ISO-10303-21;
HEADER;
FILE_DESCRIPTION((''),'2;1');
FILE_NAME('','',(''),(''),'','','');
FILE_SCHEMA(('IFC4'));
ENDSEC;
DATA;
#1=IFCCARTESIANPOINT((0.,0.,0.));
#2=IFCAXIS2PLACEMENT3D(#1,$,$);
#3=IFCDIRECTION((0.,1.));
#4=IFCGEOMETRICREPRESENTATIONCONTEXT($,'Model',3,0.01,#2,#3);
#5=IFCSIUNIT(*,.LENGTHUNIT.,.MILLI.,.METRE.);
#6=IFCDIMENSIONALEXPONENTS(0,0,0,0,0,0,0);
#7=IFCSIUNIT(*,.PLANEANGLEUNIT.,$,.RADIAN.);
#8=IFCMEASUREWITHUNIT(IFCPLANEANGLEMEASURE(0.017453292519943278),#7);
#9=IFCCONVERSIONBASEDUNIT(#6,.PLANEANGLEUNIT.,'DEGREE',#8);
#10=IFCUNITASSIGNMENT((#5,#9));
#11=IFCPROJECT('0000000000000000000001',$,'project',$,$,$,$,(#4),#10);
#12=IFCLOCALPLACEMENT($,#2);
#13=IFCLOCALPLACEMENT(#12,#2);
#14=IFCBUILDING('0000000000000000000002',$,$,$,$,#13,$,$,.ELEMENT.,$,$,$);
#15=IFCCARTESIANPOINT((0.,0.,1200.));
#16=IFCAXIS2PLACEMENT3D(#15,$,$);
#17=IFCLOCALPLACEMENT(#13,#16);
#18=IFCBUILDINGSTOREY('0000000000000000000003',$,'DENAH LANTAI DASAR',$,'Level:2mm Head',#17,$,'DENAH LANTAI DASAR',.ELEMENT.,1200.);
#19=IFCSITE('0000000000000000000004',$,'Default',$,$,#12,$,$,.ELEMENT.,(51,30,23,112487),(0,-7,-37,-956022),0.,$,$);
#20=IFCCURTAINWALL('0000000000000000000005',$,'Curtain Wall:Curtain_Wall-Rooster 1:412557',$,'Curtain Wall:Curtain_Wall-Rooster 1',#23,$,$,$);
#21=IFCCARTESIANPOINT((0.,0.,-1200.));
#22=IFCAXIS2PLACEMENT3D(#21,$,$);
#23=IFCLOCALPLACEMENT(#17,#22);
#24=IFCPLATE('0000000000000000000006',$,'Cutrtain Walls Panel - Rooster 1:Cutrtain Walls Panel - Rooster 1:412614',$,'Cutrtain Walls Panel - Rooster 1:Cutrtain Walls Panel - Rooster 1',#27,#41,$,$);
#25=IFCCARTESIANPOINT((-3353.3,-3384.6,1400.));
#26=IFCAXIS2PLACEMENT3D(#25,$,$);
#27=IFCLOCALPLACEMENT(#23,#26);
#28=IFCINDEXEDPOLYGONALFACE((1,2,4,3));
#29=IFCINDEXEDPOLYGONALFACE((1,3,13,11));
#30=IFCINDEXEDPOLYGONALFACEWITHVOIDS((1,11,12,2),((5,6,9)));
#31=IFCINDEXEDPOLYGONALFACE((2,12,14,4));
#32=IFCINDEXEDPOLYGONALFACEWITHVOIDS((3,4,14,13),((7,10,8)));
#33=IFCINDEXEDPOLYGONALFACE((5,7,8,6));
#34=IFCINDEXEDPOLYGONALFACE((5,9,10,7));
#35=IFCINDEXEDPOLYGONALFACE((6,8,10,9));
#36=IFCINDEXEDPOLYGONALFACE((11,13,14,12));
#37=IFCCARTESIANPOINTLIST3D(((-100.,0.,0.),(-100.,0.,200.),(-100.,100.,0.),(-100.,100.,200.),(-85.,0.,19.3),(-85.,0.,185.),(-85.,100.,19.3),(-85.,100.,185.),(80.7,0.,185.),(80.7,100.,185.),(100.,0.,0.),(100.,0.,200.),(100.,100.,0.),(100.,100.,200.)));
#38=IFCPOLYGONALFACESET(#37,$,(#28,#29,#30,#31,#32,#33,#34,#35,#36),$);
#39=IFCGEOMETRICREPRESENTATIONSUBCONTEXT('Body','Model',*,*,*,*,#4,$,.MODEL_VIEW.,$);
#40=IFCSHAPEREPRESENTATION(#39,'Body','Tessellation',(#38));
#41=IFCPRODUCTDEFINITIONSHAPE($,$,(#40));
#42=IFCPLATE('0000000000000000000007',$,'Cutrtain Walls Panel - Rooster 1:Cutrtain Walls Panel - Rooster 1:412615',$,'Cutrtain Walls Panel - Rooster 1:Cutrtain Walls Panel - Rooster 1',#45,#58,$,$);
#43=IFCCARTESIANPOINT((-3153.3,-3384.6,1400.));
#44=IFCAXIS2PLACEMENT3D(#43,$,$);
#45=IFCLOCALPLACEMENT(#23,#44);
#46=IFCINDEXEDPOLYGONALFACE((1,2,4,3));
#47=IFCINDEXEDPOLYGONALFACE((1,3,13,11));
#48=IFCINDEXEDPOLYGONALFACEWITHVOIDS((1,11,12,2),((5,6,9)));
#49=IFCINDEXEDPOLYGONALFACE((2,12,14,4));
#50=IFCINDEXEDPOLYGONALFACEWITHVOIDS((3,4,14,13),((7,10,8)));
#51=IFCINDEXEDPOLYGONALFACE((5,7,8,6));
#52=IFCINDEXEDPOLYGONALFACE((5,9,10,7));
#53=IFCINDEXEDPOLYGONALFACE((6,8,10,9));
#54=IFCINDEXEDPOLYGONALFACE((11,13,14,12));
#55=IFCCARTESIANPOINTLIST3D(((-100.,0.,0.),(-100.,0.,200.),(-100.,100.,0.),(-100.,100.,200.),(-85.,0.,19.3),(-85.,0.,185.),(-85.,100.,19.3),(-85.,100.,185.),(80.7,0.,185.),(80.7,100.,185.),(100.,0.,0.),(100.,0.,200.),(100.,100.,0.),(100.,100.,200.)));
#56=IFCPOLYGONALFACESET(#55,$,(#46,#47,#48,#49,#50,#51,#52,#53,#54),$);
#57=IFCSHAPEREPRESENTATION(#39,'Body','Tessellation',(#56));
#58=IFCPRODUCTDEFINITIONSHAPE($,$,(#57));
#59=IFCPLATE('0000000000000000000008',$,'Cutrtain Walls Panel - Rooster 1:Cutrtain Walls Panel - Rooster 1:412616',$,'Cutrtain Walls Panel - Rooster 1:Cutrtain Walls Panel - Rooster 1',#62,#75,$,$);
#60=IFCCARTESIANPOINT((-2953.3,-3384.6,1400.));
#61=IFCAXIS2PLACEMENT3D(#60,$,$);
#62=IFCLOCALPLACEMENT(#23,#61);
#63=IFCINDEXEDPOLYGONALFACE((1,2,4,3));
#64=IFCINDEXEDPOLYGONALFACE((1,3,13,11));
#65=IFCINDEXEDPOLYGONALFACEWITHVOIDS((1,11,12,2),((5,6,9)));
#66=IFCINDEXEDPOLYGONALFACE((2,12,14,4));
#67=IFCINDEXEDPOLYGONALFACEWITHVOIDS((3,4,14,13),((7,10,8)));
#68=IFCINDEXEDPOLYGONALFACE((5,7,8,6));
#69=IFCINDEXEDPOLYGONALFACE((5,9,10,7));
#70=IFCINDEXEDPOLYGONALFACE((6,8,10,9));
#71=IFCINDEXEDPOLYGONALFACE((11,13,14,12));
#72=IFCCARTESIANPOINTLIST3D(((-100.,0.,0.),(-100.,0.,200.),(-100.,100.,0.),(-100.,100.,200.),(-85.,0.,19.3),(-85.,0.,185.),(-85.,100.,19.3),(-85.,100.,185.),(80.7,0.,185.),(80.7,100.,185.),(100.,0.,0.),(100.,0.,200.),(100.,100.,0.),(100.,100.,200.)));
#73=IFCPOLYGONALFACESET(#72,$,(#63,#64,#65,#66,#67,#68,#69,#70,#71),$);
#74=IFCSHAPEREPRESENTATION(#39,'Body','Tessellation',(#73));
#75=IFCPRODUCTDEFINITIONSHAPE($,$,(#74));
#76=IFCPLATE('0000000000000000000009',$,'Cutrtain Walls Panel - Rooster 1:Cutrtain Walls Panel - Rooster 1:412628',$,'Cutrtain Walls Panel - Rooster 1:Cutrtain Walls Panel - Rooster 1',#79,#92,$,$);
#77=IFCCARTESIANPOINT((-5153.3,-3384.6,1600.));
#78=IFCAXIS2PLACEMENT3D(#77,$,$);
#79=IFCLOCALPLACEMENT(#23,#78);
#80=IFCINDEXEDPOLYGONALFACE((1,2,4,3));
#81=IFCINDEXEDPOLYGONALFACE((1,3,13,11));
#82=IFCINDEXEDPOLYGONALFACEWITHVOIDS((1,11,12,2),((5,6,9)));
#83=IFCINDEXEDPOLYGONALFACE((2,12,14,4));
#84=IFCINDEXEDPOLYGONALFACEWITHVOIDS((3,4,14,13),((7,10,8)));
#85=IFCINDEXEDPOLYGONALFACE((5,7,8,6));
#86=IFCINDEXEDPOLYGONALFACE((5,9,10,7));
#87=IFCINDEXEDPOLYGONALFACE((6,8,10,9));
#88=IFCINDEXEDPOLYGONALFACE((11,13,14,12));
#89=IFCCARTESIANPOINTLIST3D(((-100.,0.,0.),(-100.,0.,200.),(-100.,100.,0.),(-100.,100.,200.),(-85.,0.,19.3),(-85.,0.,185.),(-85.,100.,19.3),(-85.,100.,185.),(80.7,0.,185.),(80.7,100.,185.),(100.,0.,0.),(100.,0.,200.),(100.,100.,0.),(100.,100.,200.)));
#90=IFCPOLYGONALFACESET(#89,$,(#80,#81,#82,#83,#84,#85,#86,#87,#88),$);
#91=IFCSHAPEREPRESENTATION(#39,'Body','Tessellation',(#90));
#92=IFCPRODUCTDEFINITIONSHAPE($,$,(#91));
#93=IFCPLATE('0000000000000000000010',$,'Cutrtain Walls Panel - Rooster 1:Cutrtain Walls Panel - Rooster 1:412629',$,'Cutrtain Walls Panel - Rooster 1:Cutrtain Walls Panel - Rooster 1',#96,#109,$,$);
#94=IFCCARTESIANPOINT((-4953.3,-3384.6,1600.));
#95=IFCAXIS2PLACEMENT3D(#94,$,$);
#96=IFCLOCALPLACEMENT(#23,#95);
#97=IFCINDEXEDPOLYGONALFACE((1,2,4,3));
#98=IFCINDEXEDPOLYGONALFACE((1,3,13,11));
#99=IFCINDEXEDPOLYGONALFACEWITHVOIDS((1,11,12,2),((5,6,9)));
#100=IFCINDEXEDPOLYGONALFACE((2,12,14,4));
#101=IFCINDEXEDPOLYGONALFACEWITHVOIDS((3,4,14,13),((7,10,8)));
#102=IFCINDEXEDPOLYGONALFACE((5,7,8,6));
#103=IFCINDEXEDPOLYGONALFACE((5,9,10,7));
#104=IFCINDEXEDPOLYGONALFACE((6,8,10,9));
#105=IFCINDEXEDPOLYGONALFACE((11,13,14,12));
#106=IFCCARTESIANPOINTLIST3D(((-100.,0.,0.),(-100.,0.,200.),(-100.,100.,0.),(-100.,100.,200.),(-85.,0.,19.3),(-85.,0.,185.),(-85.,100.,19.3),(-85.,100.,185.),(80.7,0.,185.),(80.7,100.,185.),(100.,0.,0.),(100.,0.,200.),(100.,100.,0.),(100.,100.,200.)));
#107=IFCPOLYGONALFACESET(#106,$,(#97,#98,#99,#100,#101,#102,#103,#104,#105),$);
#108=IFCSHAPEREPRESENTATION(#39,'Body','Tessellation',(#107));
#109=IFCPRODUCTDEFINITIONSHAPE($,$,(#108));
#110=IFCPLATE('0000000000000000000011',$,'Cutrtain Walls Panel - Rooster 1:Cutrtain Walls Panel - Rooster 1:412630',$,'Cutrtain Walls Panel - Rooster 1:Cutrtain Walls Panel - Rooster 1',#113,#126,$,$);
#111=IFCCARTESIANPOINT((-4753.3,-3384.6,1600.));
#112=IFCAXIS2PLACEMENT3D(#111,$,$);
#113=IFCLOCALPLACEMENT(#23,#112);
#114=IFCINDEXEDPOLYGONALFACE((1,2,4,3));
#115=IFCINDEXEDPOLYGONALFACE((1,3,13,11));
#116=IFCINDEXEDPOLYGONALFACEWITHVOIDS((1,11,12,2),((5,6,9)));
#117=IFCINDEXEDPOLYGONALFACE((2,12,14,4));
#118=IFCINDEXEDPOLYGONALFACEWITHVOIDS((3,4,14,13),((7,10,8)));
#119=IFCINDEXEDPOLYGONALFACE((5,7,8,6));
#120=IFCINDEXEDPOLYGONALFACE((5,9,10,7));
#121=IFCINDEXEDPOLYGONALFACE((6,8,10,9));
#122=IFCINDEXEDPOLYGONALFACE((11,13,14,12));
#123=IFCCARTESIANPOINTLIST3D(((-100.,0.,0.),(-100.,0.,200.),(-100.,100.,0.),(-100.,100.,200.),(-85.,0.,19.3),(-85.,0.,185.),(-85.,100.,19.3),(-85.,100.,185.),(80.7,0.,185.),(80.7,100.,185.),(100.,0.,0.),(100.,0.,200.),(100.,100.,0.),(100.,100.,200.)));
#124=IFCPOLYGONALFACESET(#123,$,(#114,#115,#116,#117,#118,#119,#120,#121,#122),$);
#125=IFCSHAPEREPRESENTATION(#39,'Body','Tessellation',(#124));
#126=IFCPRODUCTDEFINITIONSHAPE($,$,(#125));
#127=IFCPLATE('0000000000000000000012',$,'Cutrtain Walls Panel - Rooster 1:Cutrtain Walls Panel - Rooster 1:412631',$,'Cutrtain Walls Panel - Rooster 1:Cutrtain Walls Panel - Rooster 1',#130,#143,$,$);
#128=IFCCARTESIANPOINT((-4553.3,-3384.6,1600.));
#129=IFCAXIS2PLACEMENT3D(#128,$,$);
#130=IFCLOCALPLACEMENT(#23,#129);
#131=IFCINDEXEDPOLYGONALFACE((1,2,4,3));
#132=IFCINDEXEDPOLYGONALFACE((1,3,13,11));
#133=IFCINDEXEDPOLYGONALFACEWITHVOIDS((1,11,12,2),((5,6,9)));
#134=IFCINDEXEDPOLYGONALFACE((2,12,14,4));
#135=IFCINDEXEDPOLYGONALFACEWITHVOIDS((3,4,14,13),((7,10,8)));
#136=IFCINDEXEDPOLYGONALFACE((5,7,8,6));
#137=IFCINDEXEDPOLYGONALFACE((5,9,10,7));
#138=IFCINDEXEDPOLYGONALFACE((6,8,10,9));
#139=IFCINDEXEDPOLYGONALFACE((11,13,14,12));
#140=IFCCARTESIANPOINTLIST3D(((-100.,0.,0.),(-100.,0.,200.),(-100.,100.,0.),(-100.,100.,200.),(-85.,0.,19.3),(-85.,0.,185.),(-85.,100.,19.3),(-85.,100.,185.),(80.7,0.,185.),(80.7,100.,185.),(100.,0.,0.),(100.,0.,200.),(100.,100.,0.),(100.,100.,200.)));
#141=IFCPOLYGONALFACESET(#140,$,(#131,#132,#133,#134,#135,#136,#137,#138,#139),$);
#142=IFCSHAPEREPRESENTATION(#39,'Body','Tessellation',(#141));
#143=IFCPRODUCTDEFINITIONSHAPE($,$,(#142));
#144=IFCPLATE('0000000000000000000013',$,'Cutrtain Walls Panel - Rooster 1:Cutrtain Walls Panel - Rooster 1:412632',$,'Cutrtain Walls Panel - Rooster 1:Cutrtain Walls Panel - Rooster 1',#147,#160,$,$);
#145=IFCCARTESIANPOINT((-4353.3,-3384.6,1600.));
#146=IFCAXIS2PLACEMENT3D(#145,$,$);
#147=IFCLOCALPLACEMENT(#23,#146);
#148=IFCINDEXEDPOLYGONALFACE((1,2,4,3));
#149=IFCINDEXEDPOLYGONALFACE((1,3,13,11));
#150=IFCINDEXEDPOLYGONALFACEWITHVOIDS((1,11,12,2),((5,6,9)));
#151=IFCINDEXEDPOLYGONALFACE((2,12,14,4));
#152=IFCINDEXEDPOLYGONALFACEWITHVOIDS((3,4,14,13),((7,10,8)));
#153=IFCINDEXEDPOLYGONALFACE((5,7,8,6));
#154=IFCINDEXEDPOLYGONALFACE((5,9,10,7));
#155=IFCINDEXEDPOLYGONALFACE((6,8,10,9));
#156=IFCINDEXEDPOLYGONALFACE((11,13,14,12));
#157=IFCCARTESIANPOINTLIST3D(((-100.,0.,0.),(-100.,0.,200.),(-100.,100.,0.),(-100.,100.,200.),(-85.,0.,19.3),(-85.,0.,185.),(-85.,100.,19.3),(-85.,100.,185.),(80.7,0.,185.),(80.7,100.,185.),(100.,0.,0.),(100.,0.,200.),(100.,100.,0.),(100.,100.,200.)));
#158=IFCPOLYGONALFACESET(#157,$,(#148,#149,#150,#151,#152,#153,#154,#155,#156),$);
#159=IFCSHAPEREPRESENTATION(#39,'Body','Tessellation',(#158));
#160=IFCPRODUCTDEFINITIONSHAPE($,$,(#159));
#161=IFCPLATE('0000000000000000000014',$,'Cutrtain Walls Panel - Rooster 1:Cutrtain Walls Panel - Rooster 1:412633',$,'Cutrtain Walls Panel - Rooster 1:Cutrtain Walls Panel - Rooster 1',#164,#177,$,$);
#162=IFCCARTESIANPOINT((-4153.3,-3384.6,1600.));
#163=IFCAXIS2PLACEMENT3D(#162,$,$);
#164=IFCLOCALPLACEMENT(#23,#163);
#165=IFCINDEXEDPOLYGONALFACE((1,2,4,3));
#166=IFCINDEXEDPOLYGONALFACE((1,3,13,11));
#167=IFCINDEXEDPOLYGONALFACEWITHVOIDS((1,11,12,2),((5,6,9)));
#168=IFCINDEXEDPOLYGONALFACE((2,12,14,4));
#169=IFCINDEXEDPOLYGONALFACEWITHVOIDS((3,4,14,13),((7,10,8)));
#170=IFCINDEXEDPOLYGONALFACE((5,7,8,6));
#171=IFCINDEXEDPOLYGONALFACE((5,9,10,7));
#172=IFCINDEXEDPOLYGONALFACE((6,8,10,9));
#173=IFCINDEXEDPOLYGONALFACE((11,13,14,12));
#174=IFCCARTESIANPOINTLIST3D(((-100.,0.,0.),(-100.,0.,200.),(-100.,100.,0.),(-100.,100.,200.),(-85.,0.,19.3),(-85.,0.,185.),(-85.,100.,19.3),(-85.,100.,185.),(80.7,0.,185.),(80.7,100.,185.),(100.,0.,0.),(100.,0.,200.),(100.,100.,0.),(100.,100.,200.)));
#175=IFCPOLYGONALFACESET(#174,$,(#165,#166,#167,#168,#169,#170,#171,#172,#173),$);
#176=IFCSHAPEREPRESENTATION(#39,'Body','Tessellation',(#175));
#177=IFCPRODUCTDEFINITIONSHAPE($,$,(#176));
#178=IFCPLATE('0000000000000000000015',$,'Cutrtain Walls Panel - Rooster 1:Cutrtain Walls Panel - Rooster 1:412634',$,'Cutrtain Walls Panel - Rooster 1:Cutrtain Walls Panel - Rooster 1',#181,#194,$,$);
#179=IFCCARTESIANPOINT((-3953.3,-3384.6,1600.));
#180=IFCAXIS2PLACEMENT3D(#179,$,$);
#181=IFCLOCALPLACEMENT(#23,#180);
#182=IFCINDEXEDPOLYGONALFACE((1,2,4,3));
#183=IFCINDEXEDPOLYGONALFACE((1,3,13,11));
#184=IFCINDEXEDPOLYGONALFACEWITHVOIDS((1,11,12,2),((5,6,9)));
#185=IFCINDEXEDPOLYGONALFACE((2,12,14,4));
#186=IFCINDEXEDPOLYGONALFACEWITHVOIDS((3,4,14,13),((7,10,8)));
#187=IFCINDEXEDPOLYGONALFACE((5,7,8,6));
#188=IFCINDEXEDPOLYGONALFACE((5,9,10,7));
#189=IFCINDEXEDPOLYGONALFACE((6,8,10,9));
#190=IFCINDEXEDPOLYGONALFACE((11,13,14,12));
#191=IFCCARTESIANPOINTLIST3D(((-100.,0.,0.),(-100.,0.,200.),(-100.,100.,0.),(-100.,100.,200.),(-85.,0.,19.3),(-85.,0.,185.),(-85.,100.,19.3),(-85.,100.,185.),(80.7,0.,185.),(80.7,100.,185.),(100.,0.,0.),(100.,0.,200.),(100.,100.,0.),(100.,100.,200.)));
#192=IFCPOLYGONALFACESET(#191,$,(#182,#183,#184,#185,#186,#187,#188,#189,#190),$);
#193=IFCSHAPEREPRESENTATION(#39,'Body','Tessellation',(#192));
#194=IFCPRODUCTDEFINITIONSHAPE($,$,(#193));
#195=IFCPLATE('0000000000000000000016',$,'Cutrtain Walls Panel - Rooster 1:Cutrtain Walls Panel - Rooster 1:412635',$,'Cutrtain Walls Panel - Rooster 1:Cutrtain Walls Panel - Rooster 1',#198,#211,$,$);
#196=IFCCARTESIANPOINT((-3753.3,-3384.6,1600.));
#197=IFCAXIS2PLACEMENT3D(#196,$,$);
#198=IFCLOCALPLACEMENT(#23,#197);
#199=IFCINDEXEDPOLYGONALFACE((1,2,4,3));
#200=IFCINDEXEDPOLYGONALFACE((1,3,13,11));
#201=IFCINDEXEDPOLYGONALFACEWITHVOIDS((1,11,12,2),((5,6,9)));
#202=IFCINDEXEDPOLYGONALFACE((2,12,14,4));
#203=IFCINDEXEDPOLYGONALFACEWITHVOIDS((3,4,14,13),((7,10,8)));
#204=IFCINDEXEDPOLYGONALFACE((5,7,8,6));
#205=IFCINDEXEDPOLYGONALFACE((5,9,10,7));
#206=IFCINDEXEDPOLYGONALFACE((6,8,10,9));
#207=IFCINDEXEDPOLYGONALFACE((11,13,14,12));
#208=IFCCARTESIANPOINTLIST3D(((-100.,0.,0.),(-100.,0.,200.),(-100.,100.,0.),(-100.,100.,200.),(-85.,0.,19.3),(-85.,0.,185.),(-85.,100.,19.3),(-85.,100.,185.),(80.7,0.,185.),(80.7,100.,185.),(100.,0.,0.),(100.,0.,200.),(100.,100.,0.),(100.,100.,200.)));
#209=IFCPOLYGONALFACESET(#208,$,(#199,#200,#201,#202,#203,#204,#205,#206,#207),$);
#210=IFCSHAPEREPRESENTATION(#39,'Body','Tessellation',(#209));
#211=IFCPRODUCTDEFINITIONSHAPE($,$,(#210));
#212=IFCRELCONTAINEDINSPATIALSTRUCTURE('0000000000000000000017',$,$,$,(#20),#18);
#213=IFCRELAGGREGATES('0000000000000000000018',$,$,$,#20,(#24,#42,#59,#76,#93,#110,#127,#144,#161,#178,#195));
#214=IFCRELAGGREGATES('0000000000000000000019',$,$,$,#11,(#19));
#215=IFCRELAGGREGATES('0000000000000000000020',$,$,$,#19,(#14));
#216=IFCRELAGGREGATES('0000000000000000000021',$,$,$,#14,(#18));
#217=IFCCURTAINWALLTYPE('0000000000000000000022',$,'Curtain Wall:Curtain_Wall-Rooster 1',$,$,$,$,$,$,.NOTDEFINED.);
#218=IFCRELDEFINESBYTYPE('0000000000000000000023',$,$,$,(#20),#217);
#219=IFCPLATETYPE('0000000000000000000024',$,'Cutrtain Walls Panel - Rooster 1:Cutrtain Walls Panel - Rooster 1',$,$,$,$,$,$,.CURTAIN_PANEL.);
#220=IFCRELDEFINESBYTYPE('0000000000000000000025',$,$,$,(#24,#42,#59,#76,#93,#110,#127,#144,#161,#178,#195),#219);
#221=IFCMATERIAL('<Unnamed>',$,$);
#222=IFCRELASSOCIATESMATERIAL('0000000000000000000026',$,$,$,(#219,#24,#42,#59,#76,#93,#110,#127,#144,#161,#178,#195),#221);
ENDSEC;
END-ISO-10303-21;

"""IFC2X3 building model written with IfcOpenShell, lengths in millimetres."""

from ifc_helpers import new_model, entity, si_unit, converted_unit, direction, frame, origin, place, context, subcontext, project, spatial, polyline, outline, extrude, source, transform, mapped, material, type_object, type_shapes, element, aggregate, save


model = new_model("IFC2X3")

# Units and contexts
model_context = context("Model", 3, precision=0.01, world=origin(), true_north=direction((0.0, 1.0)))
body_context = subcontext(model_context, "Body", "Model", "MODEL_VIEW")
ifc_project = project(units=[si_unit("LENGTHUNIT", "METRE", prefix="MILLI"), converted_unit("PLANEANGLEUNIT", "DEGREE", entity("IfcPlaneAngleMeasure", 0.017453292519943278), si_unit("PLANEANGLEUNIT", "RADIAN"), dimensions=[0, 0, 0, 0, 0, 0, 0])], contexts=[model_context])

# Site, building, storey
site_placement = place(None, origin())
site = spatial("IfcSite", under=ifc_project, at=site_placement, Name="Default", CompositionType="ELEMENT", RefLatitude=(51, 30, 23, 112487), RefLongitude=(0, -7, -37, -956022), RefElevation=0.0)
building_placement = place(site_placement, origin())
building = spatial("IfcBuilding", under=site, at=building_placement, CompositionType="ELEMENT")
storey_placement = place(building_placement, frame((0.0, 0.0, 1200.0)))
storey = spatial("IfcBuildingStorey", under=building, at=storey_placement, Name="DENAH LANTAI DASAR", ObjectType="Level:2mm Head", LongName="DENAH LANTAI DASAR", CompositionType="ELEMENT", Elevation=1200.0)

# Curtain wall, plates
curtain_wall_type = type_object("IfcCurtainWallType", Name="Curtain Wall:Curtain_Wall-Rooster 1", PredefinedType="NOTDEFINED")
curtain_wall_placement = place(storey_placement, frame((0.0, 0.0, -1200.0)))
curtain_wall = element("IfcCurtainWall", 1, at=curtain_wall_placement, inside=storey, type_object=curtain_wall_type, Name="Curtain Wall:Curtain_Wall-Rooster 1:412557", ObjectType="Curtain Wall:Curtain_Wall-Rooster 1")
ifc_material = material(Name="<Unnamed>")
plate_type = type_object("IfcPlateType", Name="Cutrtain Walls Panel - Rooster 1:Cutrtain Walls Panel - Rooster 1", PredefinedType="CURTAIN_PANEL", material=ifc_material)
shared_shape = source(origin(), body_context, "Body", "SweptSolid", [
    extrude(outline(polyline([(-100.0, -100.0), (100.0, -100.0), (100.0, 100.0), (-100.0, 100.0), (-100.0, -100.0)]), holes=[polyline([(80.7, 85.0), (-85.0, -80.7), (-85.0, 85.0), (80.7, 85.0)])]), frame((0.0, 0.0, 100.0), z_axis=(0.0, 1.0, 0.0), x_axis=(0.0, 0.0, -1.0)), (0.0, 0.0, 1.0), 100.0),
])
type_shapes(plate_type, [shared_shape])
plate_1_placement = place(curtain_wall_placement, frame((-3353.3, -3384.6, 1400.0)))
plate_1 = element("IfcPlate", 2, at=plate_1_placement, type_object=plate_type, material=ifc_material, Name="Cutrtain Walls Panel - Rooster 1:Cutrtain Walls Panel - Rooster 1:412614", ObjectType="Cutrtain Walls Panel - Rooster 1:Cutrtain Walls Panel - Rooster 1", context=body_context, shape_type="MappedRepresentation", body=[
    mapped(shared_shape, transform((0.0, 0.0, 0.0), scale=1.0)),
])
plate_2_placement = place(curtain_wall_placement, frame((-3153.3, -3384.6, 1400.0)))
plate_2 = element("IfcPlate", 3, at=plate_2_placement, type_object=plate_type, material=ifc_material, Name="Cutrtain Walls Panel - Rooster 1:Cutrtain Walls Panel - Rooster 1:412615", ObjectType="Cutrtain Walls Panel - Rooster 1:Cutrtain Walls Panel - Rooster 1", context=body_context, shape_type="MappedRepresentation", body=[
    mapped(shared_shape, transform((0.0, 0.0, 0.0), scale=1.0)),
])
plate_3_placement = place(curtain_wall_placement, frame((-2953.3, -3384.6, 1400.0)))
plate_3 = element("IfcPlate", 4, at=plate_3_placement, type_object=plate_type, material=ifc_material, Name="Cutrtain Walls Panel - Rooster 1:Cutrtain Walls Panel - Rooster 1:412616", ObjectType="Cutrtain Walls Panel - Rooster 1:Cutrtain Walls Panel - Rooster 1", context=body_context, shape_type="MappedRepresentation", body=[
    mapped(shared_shape, transform((0.0, 0.0, 0.0), scale=1.0)),
])
plate_4_placement = place(curtain_wall_placement, frame((-5153.3, -3384.6, 1600.0)))
plate_4 = element("IfcPlate", 5, at=plate_4_placement, type_object=plate_type, material=ifc_material, Name="Cutrtain Walls Panel - Rooster 1:Cutrtain Walls Panel - Rooster 1:412628", ObjectType="Cutrtain Walls Panel - Rooster 1:Cutrtain Walls Panel - Rooster 1", context=body_context, shape_type="MappedRepresentation", body=[
    mapped(shared_shape, transform((0.0, 0.0, 0.0), scale=1.0)),
])
plate_5_placement = place(curtain_wall_placement, frame((-4953.3, -3384.6, 1600.0)))
plate_5 = element("IfcPlate", 6, at=plate_5_placement, type_object=plate_type, material=ifc_material, Name="Cutrtain Walls Panel - Rooster 1:Cutrtain Walls Panel - Rooster 1:412629", ObjectType="Cutrtain Walls Panel - Rooster 1:Cutrtain Walls Panel - Rooster 1", context=body_context, shape_type="MappedRepresentation", body=[
    mapped(shared_shape, transform((0.0, 0.0, 0.0), scale=1.0)),
])
plate_6_placement = place(curtain_wall_placement, frame((-4753.3, -3384.6, 1600.0)))
plate_6 = element("IfcPlate", 7, at=plate_6_placement, type_object=plate_type, material=ifc_material, Name="Cutrtain Walls Panel - Rooster 1:Cutrtain Walls Panel - Rooster 1:412630", ObjectType="Cutrtain Walls Panel - Rooster 1:Cutrtain Walls Panel - Rooster 1", context=body_context, shape_type="MappedRepresentation", body=[
    mapped(shared_shape, transform((0.0, 0.0, 0.0), scale=1.0)),
])
plate_7_placement = place(curtain_wall_placement, frame((-4553.3, -3384.6, 1600.0)))
plate_7 = element("IfcPlate", 8, at=plate_7_placement, type_object=plate_type, material=ifc_material, Name="Cutrtain Walls Panel - Rooster 1:Cutrtain Walls Panel - Rooster 1:412631", ObjectType="Cutrtain Walls Panel - Rooster 1:Cutrtain Walls Panel - Rooster 1", context=body_context, shape_type="MappedRepresentation", body=[
    mapped(shared_shape, transform((0.0, 0.0, 0.0), scale=1.0)),
])
plate_8_placement = place(curtain_wall_placement, frame((-4353.3, -3384.6, 1600.0)))
plate_8 = element("IfcPlate", 9, at=plate_8_placement, type_object=plate_type, material=ifc_material, Name="Cutrtain Walls Panel - Rooster 1:Cutrtain Walls Panel - Rooster 1:412632", ObjectType="Cutrtain Walls Panel - Rooster 1:Cutrtain Walls Panel - Rooster 1", context=body_context, shape_type="MappedRepresentation", body=[
    mapped(shared_shape, transform((0.0, 0.0, 0.0), scale=1.0)),
])
plate_9_placement = place(curtain_wall_placement, frame((-4153.3, -3384.6, 1600.0)))
plate_9 = element("IfcPlate", 10, at=plate_9_placement, type_object=plate_type, material=ifc_material, Name="Cutrtain Walls Panel - Rooster 1:Cutrtain Walls Panel - Rooster 1:412633", ObjectType="Cutrtain Walls Panel - Rooster 1:Cutrtain Walls Panel - Rooster 1", context=body_context, shape_type="MappedRepresentation", body=[
    mapped(shared_shape, transform((0.0, 0.0, 0.0), scale=1.0)),
])
plate_10_placement = place(curtain_wall_placement, frame((-3953.3, -3384.6, 1600.0)))
plate_10 = element("IfcPlate", 11, at=plate_10_placement, type_object=plate_type, material=ifc_material, Name="Cutrtain Walls Panel - Rooster 1:Cutrtain Walls Panel - Rooster 1:412634", ObjectType="Cutrtain Walls Panel - Rooster 1:Cutrtain Walls Panel - Rooster 1", context=body_context, shape_type="MappedRepresentation", body=[
    mapped(shared_shape, transform((0.0, 0.0, 0.0), scale=1.0)),
])
plate_11_placement = place(curtain_wall_placement, frame((-3753.3, -3384.6, 1600.0)))
plate_11 = element("IfcPlate", 12, at=plate_11_placement, type_object=plate_type, material=ifc_material, Name="Cutrtain Walls Panel - Rooster 1:Cutrtain Walls Panel - Rooster 1:412635", ObjectType="Cutrtain Walls Panel - Rooster 1:Cutrtain Walls Panel - Rooster 1", context=body_context, shape_type="MappedRepresentation", body=[
    mapped(shared_shape, transform((0.0, 0.0, 0.0), scale=1.0)),
])
aggregate(curtain_wall, [plate_1, plate_2, plate_3, plate_4, plate_5, plate_6, plate_7, plate_8, plate_9, plate_10, plate_11])

save(model, "model.ifc")
